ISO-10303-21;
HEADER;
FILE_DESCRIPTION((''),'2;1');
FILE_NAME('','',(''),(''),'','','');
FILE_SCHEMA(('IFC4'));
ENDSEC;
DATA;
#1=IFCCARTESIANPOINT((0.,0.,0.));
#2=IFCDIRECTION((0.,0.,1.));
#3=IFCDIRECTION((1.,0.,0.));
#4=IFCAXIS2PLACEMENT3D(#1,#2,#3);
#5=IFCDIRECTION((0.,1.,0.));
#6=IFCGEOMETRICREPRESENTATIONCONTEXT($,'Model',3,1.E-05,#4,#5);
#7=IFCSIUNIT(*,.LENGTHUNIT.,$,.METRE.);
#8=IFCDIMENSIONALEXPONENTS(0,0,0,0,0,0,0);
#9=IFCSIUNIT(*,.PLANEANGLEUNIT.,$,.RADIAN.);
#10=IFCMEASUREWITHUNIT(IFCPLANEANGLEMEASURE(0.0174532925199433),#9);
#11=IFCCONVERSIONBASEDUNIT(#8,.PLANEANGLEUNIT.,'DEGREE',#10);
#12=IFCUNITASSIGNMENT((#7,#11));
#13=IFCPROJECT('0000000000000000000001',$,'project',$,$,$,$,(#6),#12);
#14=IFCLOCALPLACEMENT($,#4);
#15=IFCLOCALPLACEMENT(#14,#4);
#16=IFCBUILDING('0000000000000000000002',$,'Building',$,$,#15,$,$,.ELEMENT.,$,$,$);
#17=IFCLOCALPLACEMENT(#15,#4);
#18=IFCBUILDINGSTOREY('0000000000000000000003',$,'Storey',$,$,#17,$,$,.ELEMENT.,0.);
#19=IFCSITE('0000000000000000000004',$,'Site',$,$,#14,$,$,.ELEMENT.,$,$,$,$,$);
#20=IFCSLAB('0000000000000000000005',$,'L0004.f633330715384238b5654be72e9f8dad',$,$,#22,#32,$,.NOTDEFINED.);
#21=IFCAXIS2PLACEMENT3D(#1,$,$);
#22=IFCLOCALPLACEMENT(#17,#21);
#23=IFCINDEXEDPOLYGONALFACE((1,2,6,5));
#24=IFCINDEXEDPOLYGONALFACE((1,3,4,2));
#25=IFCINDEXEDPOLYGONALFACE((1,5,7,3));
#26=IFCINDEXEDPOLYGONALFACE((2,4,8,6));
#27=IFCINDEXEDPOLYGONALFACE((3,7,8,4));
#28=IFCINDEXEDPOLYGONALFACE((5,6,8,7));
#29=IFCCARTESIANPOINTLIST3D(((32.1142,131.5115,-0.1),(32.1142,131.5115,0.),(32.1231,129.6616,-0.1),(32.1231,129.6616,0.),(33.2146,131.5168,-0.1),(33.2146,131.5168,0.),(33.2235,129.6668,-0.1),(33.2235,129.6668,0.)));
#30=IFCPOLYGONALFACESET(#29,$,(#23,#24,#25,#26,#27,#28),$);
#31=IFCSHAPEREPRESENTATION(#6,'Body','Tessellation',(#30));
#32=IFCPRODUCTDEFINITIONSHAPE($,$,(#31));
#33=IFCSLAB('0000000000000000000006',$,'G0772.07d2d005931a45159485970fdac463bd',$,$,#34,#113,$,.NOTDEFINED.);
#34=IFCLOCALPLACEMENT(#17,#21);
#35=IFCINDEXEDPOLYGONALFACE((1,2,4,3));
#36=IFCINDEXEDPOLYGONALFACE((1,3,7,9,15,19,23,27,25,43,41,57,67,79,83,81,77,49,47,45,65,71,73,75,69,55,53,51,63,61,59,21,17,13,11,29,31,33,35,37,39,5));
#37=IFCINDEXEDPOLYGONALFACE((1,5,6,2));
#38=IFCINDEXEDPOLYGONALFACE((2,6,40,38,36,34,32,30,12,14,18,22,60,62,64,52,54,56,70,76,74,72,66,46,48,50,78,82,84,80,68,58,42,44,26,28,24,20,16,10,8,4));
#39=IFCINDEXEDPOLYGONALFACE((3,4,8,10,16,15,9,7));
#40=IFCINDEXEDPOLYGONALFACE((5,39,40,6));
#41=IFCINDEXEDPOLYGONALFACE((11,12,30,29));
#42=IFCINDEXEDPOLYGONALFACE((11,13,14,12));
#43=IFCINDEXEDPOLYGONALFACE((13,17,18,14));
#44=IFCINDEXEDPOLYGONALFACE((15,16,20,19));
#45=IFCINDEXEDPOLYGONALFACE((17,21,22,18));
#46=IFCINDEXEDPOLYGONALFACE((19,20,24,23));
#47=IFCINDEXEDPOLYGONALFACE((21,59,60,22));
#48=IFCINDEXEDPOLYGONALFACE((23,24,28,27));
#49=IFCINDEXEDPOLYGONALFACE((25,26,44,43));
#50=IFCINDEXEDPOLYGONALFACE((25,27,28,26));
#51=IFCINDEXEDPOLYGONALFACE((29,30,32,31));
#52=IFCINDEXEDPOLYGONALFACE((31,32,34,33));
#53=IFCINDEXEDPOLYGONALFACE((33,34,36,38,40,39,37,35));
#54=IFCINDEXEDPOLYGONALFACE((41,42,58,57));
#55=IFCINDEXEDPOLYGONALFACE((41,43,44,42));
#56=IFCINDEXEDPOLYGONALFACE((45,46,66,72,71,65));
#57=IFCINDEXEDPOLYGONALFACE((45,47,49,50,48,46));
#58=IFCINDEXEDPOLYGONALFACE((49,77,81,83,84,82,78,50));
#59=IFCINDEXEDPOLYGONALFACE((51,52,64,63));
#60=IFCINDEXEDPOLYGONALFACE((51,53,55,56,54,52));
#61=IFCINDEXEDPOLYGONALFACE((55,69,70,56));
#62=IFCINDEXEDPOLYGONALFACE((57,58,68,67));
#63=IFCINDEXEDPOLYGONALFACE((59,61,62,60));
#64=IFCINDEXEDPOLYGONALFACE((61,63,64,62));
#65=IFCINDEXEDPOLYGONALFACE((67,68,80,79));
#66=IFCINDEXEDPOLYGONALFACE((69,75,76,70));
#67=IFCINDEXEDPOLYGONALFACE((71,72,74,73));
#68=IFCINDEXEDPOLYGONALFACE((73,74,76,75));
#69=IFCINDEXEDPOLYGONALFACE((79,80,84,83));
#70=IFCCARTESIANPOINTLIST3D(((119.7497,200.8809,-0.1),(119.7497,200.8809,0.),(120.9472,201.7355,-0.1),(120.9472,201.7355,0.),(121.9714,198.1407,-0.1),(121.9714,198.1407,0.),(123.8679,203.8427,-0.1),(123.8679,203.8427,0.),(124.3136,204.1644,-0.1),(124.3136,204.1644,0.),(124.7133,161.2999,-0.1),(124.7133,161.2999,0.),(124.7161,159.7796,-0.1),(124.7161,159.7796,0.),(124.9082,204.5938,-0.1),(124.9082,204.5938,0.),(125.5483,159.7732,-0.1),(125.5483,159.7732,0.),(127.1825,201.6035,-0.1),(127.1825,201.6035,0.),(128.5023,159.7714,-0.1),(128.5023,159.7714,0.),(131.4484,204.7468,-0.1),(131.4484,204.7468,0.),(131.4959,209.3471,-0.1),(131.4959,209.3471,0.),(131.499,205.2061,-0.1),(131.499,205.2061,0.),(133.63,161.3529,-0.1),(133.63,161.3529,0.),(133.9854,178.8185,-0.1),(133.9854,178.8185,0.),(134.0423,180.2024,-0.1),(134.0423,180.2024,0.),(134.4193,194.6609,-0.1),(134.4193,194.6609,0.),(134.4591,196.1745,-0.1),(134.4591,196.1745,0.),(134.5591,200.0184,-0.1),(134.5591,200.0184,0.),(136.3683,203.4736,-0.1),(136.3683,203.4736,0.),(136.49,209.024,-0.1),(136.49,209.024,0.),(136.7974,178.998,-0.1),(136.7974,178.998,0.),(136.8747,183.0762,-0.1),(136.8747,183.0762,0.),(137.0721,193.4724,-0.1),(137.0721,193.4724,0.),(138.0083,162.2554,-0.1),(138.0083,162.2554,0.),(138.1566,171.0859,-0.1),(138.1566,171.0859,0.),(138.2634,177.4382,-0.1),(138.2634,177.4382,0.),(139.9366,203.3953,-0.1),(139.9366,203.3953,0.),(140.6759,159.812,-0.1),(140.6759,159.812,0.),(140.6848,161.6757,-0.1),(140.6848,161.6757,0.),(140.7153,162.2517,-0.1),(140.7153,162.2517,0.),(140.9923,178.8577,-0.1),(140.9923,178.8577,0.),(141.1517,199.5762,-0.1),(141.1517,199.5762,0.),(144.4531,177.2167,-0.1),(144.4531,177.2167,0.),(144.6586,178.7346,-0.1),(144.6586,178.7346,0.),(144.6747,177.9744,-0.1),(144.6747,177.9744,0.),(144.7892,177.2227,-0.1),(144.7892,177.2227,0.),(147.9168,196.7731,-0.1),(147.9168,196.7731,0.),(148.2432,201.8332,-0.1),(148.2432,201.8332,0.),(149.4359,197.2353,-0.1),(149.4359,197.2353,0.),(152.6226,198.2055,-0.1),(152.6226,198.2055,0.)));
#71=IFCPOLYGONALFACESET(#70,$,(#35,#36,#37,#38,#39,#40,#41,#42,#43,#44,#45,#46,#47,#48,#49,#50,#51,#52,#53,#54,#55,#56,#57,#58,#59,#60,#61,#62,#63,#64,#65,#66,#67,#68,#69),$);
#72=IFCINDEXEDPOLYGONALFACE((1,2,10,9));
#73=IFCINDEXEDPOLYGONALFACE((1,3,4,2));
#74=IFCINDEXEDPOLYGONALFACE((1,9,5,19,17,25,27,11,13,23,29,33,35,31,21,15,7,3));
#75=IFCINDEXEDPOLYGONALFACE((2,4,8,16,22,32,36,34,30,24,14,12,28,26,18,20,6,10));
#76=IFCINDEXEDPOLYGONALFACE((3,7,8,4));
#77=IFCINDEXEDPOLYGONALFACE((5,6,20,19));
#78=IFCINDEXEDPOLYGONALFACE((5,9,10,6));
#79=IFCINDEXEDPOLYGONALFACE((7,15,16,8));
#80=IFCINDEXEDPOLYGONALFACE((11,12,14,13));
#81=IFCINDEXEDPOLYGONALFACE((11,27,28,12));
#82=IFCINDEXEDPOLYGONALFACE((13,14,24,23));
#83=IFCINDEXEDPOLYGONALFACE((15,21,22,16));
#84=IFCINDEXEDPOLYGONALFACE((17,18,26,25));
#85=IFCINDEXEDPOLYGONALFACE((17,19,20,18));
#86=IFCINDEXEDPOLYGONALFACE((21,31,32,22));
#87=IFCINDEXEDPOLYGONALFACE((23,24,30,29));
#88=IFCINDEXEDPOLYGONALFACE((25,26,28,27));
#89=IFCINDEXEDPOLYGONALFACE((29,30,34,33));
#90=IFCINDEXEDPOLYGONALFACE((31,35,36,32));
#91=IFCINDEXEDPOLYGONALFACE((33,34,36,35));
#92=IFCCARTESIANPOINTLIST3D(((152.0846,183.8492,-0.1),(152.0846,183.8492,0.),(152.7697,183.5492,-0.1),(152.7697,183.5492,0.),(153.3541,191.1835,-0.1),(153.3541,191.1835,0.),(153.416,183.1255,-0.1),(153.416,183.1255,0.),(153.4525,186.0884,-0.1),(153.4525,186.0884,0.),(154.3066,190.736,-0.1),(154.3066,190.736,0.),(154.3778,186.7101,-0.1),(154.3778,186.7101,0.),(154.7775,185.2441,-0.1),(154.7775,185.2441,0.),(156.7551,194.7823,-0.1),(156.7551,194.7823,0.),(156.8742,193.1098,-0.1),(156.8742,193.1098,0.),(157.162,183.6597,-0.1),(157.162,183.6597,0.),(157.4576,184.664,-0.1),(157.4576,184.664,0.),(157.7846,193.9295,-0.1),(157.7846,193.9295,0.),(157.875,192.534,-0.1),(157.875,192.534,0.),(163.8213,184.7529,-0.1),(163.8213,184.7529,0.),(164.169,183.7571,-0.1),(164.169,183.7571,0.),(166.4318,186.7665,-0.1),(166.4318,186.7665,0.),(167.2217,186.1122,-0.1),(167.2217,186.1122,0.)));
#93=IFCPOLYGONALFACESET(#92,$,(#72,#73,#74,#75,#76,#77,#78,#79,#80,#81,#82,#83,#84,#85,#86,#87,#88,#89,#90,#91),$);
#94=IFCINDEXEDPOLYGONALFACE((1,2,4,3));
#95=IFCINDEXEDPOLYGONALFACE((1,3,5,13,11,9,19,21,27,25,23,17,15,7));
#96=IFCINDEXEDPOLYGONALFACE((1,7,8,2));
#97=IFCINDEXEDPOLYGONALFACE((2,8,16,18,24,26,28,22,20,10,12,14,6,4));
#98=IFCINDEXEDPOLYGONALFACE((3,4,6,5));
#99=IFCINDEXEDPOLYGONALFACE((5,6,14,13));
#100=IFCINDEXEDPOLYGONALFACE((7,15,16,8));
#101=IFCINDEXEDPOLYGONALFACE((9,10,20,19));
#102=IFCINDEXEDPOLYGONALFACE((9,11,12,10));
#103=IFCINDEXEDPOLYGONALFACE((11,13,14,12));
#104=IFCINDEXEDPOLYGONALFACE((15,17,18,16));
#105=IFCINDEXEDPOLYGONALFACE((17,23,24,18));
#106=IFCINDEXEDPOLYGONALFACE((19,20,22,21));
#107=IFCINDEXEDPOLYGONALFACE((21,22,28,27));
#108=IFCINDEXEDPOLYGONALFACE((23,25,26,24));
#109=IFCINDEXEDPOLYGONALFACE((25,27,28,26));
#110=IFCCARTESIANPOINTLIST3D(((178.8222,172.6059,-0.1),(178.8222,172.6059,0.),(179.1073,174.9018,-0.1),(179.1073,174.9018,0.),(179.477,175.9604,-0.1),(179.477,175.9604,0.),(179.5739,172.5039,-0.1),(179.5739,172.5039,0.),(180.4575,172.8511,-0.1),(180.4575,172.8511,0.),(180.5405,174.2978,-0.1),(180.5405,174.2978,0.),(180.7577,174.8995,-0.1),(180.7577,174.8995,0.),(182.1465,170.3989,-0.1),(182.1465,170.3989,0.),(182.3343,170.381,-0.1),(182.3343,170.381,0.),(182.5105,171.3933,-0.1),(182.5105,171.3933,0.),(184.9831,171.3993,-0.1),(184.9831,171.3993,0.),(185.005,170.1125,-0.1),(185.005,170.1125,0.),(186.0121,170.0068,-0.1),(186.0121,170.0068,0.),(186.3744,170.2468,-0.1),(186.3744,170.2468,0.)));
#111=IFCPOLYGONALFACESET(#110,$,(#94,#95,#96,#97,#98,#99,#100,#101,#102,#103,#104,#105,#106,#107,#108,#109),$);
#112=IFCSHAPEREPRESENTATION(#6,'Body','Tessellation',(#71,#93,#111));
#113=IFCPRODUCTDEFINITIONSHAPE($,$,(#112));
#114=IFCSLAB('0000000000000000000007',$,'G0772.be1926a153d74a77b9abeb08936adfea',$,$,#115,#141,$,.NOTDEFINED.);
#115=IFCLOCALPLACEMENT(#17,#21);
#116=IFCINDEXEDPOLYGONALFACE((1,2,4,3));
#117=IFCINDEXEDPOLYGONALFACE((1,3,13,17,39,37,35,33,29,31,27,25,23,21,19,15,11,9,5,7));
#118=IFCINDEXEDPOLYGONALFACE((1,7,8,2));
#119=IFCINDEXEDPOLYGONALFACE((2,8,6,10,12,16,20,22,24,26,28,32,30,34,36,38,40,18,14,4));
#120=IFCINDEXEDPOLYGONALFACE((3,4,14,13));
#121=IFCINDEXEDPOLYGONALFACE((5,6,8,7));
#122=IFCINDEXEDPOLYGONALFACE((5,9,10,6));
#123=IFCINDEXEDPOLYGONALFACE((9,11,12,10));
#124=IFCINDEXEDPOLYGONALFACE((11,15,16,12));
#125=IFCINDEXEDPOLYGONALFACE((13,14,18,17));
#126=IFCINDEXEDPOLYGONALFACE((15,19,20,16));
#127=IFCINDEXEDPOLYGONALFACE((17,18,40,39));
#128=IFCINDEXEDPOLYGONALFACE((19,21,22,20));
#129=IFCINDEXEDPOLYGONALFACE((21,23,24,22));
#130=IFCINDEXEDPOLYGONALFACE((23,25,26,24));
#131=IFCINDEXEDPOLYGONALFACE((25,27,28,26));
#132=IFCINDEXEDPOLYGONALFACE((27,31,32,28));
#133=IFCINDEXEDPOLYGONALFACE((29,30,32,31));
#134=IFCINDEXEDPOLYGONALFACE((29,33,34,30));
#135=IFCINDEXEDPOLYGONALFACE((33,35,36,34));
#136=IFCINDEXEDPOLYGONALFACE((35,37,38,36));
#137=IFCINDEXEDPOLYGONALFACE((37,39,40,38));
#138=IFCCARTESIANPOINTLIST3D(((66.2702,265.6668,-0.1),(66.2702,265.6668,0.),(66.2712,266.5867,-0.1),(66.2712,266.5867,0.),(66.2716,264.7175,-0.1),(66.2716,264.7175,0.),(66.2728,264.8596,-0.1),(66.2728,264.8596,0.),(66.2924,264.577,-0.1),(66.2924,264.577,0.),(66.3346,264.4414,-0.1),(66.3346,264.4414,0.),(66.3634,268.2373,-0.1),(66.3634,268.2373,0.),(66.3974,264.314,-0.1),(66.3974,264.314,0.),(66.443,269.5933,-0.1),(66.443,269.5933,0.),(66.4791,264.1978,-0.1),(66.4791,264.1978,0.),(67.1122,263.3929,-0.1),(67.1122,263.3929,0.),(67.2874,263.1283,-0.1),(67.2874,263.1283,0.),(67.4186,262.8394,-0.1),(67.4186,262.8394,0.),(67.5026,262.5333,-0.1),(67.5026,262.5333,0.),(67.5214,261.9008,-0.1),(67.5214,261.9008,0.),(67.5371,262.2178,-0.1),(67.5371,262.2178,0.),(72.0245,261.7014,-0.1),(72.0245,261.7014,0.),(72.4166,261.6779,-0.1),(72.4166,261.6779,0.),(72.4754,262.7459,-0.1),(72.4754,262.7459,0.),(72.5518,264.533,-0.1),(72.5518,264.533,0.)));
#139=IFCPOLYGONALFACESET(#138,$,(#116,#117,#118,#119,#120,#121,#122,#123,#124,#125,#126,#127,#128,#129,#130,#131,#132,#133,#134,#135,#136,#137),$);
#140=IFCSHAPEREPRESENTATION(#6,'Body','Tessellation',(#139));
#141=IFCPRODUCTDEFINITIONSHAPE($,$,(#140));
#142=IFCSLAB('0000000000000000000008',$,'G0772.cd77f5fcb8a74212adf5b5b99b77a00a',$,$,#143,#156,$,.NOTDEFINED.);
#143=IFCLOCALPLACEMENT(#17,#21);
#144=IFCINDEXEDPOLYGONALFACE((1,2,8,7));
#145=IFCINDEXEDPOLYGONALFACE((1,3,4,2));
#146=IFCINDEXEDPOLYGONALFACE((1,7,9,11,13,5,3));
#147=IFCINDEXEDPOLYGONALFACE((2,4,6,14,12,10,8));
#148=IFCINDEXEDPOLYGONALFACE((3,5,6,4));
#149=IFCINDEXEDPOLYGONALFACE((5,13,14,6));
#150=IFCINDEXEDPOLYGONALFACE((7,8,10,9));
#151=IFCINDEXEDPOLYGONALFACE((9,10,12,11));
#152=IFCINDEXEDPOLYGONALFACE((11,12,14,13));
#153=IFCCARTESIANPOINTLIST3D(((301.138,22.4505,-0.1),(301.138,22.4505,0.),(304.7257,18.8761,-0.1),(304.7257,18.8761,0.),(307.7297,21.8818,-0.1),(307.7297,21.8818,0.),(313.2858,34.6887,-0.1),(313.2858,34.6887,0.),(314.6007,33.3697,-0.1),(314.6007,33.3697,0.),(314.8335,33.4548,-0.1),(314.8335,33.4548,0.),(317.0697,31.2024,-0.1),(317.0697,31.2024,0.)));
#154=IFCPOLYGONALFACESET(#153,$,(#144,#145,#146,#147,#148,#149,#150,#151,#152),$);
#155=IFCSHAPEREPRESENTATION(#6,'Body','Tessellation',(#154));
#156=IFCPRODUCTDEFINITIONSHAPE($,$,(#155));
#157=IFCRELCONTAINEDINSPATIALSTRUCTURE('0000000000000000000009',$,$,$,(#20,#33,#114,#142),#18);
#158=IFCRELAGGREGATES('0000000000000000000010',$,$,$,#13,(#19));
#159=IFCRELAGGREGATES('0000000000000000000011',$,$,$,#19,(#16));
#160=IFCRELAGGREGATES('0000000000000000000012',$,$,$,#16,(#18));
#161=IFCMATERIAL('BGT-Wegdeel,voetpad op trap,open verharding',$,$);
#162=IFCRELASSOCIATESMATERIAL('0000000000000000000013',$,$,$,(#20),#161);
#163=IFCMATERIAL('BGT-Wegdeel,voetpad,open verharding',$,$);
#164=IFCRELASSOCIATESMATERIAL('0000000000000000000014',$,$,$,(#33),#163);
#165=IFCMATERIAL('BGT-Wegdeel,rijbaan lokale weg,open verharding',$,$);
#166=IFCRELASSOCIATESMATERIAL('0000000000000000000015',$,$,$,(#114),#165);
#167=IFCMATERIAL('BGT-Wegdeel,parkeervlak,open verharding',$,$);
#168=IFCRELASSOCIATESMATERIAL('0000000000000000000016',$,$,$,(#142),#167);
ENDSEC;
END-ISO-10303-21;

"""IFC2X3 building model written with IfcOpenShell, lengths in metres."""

from ifc_helpers import new_model, entity, si_unit, converted_unit, direction, frame, origin_with_axes, place, context, project, spatial, polyline, outline, extrude, material, element, save


model = new_model("IFC2X3")

# Units and contexts
model_context = context("Model", 3, precision=1e-05, world=origin_with_axes(), true_north=direction((0.0, 1.0, 0.0)))
ifc_project = project(units=[si_unit("LENGTHUNIT", "METRE"), converted_unit("PLANEANGLEUNIT", "DEGREE", entity("IfcPlaneAngleMeasure", 0.0174532925199433), si_unit("PLANEANGLEUNIT", "RADIAN"), dimensions=[0, 0, 0, 0, 0, 0, 0])], contexts=[model_context])

# Site, building, storey
site_placement = place(None, origin_with_axes())
site = spatial("IfcSite", under=ifc_project, at=site_placement, Name="Site", CompositionType="ELEMENT")
building_placement = place(site_placement, origin_with_axes())
building = spatial("IfcBuilding", under=site, at=building_placement, Name="Building", CompositionType="ELEMENT")
storey_placement = place(building_placement, origin_with_axes())
storey = spatial("IfcBuildingStorey", under=building, at=storey_placement, Name="Storey", CompositionType="ELEMENT", Elevation=0.0)

# Slabs
ifc_material_1 = material(Name="BGT-Wegdeel,voetpad,open verharding")
ifc_material_2 = material(Name="BGT-Wegdeel,voetpad op trap,open verharding")
ifc_material_3 = material(Name="BGT-Wegdeel,parkeervlak,open verharding")
ifc_material_4 = material(Name="BGT-Wegdeel,rijbaan lokale weg,open verharding")
slab_1_placement = place(storey_placement, frame((0.0, 0.0, -0.1), z_axis=(0.0, 0.0, 1.0), x_axis=(1.0, 0.0, 0.0)))
element("IfcSlab", 1, at=slab_1_placement, inside=storey, material=ifc_material_2, Name="L0004.f633330715384238b5654be72e9f8dad", PredefinedType="NOTDEFINED", context=model_context, shape_type="SweptSolid", body=[
    extrude(outline(polyline([(33.2235, 129.6668), (32.1231, 129.6616), (32.1142, 131.5115), (33.2146, 131.5168), (33.2235, 129.6668)])), origin_with_axes(), (0.0, 0.0, 1.0), 0.1),
])
slab_2_placement = place(storey_placement, frame((0.0, 0.0, -0.1), z_axis=(0.0, 0.0, 1.0), x_axis=(1.0, 0.0, 0.0)))
element("IfcSlab", 2, at=slab_2_placement, inside=storey, material=ifc_material_1, Name="G0772.07d2d005931a45159485970fdac463bd", PredefinedType="NOTDEFINED", context=model_context, shape_type="SweptSolid", body=[
    extrude(outline(polyline([(149.4359, 197.2353), (147.9168, 196.7731), (137.0721, 193.4724), (136.8747, 183.0762), (136.7974, 178.998), (140.9923, 178.8577), (144.6586, 178.7346), (144.6747, 177.9744), (144.7892, 177.2227), (144.4531, 177.2167), (138.2634, 177.4382), (138.1566, 171.0859), (138.0083, 162.2554), (140.7153, 162.2517), (140.6848, 161.6757), (140.6759, 159.812), (128.5023, 159.7714), (125.5483, 159.7732), (124.7161, 159.7796), (124.7133, 161.2999), (133.63, 161.3529), (133.9854, 178.8185), (134.0423, 180.2024), (134.4193, 194.6609), (134.4591, 196.1745), (134.5591, 200.0184), (121.9714, 198.1407), (119.7497, 200.8809), (120.9472, 201.7355), (123.8679, 203.8427), (124.3136, 204.1644), (124.9082, 204.5938), (127.1825, 201.6035), (131.4484, 204.7468), (131.499, 205.2061), (131.4959, 209.3471), (136.49, 209.024), (136.3683, 203.4736), (139.9366, 203.3953), (141.1517, 199.5762), (148.2432, 201.8332), (152.6226, 198.2055), (149.4359, 197.2353)])), origin_with_axes(), (0.0, 0.0, 1.0), 0.1),
    extrude(outline(polyline([(164.169, 183.7571), (157.162, 183.6597), (154.7775, 185.2441), (153.416, 183.1255), (152.7697, 183.5492), (152.0846, 183.8492), (153.4525, 186.0884), (153.3541, 191.1835), (156.8742, 193.1098), (156.7551, 194.7823), (157.7846, 193.9295), (157.875, 192.534), (154.3066, 190.736), (154.3778, 186.7101), (157.4576, 184.664), (163.8213, 184.7529), (166.4318, 186.7665), (167.2217, 186.1122), (164.169, 183.7571)])), origin_with_axes(), (0.0, 0.0, 1.0), 0.1),
    extrude(outline(polyline([(186.0121, 170.0068), (185.005, 170.1125), (182.3343, 170.381), (182.1465, 170.3989), (179.5739, 172.5039), (178.8222, 172.6059), (179.1073, 174.9018), (179.477, 175.9604), (180.7577, 174.8995), (180.5405, 174.2978), (180.4575, 172.8511), (182.5105, 171.3933), (184.9831, 171.3993), (186.3744, 170.2468), (186.0121, 170.0068)])), origin_with_axes(), (0.0, 0.0, 1.0), 0.1),
])
slab_3_placement = place(storey_placement, frame((0.0, 0.0, -0.1), z_axis=(0.0, 0.0, 1.0), x_axis=(1.0, 0.0, 0.0)))
element("IfcSlab", 3, at=slab_3_placement, inside=storey, material=ifc_material_4, Name="G0772.be1926a153d74a77b9abeb08936adfea", PredefinedType="NOTDEFINED", context=model_context, shape_type="SweptSolid", body=[
    extrude(outline(polyline([(72.4754, 262.7459), (72.4166, 261.6779), (72.0245, 261.7014), (67.5214, 261.9008), (67.5371, 262.2178), (67.5026, 262.5333), (67.4186, 262.8394), (67.2874, 263.1283), (67.1122, 263.3929), (66.4791, 264.1978), (66.3974, 264.314), (66.3346, 264.4414), (66.2924, 264.577), (66.2716, 264.7175), (66.2728, 264.8596), (66.2702, 265.6668), (66.2712, 266.5867), (66.3634, 268.2373), (66.443, 269.5933), (72.5518, 264.533), (72.4754, 262.7459)])), origin_with_axes(), (0.0, 0.0, 1.0), 0.1),
])
slab_4_placement = place(storey_placement, frame((0.0, 0.0, -0.1), z_axis=(0.0, 0.0, 1.0), x_axis=(1.0, 0.0, 0.0)))
element("IfcSlab", 4, at=slab_4_placement, inside=storey, material=ifc_material_3, Name="G0772.cd77f5fcb8a74212adf5b5b99b77a00a", PredefinedType="NOTDEFINED", context=model_context, shape_type="SweptSolid", body=[
    extrude(outline(polyline([(317.0697, 31.2024), (307.7297, 21.8818), (304.7257, 18.8761), (301.138, 22.4505), (313.2858, 34.6887), (314.6007, 33.3697), (314.8335, 33.4548), (317.0697, 31.2024)])), origin_with_axes(), (0.0, 0.0, 1.0), 0.1),
])

save(model, "model.ifc")
